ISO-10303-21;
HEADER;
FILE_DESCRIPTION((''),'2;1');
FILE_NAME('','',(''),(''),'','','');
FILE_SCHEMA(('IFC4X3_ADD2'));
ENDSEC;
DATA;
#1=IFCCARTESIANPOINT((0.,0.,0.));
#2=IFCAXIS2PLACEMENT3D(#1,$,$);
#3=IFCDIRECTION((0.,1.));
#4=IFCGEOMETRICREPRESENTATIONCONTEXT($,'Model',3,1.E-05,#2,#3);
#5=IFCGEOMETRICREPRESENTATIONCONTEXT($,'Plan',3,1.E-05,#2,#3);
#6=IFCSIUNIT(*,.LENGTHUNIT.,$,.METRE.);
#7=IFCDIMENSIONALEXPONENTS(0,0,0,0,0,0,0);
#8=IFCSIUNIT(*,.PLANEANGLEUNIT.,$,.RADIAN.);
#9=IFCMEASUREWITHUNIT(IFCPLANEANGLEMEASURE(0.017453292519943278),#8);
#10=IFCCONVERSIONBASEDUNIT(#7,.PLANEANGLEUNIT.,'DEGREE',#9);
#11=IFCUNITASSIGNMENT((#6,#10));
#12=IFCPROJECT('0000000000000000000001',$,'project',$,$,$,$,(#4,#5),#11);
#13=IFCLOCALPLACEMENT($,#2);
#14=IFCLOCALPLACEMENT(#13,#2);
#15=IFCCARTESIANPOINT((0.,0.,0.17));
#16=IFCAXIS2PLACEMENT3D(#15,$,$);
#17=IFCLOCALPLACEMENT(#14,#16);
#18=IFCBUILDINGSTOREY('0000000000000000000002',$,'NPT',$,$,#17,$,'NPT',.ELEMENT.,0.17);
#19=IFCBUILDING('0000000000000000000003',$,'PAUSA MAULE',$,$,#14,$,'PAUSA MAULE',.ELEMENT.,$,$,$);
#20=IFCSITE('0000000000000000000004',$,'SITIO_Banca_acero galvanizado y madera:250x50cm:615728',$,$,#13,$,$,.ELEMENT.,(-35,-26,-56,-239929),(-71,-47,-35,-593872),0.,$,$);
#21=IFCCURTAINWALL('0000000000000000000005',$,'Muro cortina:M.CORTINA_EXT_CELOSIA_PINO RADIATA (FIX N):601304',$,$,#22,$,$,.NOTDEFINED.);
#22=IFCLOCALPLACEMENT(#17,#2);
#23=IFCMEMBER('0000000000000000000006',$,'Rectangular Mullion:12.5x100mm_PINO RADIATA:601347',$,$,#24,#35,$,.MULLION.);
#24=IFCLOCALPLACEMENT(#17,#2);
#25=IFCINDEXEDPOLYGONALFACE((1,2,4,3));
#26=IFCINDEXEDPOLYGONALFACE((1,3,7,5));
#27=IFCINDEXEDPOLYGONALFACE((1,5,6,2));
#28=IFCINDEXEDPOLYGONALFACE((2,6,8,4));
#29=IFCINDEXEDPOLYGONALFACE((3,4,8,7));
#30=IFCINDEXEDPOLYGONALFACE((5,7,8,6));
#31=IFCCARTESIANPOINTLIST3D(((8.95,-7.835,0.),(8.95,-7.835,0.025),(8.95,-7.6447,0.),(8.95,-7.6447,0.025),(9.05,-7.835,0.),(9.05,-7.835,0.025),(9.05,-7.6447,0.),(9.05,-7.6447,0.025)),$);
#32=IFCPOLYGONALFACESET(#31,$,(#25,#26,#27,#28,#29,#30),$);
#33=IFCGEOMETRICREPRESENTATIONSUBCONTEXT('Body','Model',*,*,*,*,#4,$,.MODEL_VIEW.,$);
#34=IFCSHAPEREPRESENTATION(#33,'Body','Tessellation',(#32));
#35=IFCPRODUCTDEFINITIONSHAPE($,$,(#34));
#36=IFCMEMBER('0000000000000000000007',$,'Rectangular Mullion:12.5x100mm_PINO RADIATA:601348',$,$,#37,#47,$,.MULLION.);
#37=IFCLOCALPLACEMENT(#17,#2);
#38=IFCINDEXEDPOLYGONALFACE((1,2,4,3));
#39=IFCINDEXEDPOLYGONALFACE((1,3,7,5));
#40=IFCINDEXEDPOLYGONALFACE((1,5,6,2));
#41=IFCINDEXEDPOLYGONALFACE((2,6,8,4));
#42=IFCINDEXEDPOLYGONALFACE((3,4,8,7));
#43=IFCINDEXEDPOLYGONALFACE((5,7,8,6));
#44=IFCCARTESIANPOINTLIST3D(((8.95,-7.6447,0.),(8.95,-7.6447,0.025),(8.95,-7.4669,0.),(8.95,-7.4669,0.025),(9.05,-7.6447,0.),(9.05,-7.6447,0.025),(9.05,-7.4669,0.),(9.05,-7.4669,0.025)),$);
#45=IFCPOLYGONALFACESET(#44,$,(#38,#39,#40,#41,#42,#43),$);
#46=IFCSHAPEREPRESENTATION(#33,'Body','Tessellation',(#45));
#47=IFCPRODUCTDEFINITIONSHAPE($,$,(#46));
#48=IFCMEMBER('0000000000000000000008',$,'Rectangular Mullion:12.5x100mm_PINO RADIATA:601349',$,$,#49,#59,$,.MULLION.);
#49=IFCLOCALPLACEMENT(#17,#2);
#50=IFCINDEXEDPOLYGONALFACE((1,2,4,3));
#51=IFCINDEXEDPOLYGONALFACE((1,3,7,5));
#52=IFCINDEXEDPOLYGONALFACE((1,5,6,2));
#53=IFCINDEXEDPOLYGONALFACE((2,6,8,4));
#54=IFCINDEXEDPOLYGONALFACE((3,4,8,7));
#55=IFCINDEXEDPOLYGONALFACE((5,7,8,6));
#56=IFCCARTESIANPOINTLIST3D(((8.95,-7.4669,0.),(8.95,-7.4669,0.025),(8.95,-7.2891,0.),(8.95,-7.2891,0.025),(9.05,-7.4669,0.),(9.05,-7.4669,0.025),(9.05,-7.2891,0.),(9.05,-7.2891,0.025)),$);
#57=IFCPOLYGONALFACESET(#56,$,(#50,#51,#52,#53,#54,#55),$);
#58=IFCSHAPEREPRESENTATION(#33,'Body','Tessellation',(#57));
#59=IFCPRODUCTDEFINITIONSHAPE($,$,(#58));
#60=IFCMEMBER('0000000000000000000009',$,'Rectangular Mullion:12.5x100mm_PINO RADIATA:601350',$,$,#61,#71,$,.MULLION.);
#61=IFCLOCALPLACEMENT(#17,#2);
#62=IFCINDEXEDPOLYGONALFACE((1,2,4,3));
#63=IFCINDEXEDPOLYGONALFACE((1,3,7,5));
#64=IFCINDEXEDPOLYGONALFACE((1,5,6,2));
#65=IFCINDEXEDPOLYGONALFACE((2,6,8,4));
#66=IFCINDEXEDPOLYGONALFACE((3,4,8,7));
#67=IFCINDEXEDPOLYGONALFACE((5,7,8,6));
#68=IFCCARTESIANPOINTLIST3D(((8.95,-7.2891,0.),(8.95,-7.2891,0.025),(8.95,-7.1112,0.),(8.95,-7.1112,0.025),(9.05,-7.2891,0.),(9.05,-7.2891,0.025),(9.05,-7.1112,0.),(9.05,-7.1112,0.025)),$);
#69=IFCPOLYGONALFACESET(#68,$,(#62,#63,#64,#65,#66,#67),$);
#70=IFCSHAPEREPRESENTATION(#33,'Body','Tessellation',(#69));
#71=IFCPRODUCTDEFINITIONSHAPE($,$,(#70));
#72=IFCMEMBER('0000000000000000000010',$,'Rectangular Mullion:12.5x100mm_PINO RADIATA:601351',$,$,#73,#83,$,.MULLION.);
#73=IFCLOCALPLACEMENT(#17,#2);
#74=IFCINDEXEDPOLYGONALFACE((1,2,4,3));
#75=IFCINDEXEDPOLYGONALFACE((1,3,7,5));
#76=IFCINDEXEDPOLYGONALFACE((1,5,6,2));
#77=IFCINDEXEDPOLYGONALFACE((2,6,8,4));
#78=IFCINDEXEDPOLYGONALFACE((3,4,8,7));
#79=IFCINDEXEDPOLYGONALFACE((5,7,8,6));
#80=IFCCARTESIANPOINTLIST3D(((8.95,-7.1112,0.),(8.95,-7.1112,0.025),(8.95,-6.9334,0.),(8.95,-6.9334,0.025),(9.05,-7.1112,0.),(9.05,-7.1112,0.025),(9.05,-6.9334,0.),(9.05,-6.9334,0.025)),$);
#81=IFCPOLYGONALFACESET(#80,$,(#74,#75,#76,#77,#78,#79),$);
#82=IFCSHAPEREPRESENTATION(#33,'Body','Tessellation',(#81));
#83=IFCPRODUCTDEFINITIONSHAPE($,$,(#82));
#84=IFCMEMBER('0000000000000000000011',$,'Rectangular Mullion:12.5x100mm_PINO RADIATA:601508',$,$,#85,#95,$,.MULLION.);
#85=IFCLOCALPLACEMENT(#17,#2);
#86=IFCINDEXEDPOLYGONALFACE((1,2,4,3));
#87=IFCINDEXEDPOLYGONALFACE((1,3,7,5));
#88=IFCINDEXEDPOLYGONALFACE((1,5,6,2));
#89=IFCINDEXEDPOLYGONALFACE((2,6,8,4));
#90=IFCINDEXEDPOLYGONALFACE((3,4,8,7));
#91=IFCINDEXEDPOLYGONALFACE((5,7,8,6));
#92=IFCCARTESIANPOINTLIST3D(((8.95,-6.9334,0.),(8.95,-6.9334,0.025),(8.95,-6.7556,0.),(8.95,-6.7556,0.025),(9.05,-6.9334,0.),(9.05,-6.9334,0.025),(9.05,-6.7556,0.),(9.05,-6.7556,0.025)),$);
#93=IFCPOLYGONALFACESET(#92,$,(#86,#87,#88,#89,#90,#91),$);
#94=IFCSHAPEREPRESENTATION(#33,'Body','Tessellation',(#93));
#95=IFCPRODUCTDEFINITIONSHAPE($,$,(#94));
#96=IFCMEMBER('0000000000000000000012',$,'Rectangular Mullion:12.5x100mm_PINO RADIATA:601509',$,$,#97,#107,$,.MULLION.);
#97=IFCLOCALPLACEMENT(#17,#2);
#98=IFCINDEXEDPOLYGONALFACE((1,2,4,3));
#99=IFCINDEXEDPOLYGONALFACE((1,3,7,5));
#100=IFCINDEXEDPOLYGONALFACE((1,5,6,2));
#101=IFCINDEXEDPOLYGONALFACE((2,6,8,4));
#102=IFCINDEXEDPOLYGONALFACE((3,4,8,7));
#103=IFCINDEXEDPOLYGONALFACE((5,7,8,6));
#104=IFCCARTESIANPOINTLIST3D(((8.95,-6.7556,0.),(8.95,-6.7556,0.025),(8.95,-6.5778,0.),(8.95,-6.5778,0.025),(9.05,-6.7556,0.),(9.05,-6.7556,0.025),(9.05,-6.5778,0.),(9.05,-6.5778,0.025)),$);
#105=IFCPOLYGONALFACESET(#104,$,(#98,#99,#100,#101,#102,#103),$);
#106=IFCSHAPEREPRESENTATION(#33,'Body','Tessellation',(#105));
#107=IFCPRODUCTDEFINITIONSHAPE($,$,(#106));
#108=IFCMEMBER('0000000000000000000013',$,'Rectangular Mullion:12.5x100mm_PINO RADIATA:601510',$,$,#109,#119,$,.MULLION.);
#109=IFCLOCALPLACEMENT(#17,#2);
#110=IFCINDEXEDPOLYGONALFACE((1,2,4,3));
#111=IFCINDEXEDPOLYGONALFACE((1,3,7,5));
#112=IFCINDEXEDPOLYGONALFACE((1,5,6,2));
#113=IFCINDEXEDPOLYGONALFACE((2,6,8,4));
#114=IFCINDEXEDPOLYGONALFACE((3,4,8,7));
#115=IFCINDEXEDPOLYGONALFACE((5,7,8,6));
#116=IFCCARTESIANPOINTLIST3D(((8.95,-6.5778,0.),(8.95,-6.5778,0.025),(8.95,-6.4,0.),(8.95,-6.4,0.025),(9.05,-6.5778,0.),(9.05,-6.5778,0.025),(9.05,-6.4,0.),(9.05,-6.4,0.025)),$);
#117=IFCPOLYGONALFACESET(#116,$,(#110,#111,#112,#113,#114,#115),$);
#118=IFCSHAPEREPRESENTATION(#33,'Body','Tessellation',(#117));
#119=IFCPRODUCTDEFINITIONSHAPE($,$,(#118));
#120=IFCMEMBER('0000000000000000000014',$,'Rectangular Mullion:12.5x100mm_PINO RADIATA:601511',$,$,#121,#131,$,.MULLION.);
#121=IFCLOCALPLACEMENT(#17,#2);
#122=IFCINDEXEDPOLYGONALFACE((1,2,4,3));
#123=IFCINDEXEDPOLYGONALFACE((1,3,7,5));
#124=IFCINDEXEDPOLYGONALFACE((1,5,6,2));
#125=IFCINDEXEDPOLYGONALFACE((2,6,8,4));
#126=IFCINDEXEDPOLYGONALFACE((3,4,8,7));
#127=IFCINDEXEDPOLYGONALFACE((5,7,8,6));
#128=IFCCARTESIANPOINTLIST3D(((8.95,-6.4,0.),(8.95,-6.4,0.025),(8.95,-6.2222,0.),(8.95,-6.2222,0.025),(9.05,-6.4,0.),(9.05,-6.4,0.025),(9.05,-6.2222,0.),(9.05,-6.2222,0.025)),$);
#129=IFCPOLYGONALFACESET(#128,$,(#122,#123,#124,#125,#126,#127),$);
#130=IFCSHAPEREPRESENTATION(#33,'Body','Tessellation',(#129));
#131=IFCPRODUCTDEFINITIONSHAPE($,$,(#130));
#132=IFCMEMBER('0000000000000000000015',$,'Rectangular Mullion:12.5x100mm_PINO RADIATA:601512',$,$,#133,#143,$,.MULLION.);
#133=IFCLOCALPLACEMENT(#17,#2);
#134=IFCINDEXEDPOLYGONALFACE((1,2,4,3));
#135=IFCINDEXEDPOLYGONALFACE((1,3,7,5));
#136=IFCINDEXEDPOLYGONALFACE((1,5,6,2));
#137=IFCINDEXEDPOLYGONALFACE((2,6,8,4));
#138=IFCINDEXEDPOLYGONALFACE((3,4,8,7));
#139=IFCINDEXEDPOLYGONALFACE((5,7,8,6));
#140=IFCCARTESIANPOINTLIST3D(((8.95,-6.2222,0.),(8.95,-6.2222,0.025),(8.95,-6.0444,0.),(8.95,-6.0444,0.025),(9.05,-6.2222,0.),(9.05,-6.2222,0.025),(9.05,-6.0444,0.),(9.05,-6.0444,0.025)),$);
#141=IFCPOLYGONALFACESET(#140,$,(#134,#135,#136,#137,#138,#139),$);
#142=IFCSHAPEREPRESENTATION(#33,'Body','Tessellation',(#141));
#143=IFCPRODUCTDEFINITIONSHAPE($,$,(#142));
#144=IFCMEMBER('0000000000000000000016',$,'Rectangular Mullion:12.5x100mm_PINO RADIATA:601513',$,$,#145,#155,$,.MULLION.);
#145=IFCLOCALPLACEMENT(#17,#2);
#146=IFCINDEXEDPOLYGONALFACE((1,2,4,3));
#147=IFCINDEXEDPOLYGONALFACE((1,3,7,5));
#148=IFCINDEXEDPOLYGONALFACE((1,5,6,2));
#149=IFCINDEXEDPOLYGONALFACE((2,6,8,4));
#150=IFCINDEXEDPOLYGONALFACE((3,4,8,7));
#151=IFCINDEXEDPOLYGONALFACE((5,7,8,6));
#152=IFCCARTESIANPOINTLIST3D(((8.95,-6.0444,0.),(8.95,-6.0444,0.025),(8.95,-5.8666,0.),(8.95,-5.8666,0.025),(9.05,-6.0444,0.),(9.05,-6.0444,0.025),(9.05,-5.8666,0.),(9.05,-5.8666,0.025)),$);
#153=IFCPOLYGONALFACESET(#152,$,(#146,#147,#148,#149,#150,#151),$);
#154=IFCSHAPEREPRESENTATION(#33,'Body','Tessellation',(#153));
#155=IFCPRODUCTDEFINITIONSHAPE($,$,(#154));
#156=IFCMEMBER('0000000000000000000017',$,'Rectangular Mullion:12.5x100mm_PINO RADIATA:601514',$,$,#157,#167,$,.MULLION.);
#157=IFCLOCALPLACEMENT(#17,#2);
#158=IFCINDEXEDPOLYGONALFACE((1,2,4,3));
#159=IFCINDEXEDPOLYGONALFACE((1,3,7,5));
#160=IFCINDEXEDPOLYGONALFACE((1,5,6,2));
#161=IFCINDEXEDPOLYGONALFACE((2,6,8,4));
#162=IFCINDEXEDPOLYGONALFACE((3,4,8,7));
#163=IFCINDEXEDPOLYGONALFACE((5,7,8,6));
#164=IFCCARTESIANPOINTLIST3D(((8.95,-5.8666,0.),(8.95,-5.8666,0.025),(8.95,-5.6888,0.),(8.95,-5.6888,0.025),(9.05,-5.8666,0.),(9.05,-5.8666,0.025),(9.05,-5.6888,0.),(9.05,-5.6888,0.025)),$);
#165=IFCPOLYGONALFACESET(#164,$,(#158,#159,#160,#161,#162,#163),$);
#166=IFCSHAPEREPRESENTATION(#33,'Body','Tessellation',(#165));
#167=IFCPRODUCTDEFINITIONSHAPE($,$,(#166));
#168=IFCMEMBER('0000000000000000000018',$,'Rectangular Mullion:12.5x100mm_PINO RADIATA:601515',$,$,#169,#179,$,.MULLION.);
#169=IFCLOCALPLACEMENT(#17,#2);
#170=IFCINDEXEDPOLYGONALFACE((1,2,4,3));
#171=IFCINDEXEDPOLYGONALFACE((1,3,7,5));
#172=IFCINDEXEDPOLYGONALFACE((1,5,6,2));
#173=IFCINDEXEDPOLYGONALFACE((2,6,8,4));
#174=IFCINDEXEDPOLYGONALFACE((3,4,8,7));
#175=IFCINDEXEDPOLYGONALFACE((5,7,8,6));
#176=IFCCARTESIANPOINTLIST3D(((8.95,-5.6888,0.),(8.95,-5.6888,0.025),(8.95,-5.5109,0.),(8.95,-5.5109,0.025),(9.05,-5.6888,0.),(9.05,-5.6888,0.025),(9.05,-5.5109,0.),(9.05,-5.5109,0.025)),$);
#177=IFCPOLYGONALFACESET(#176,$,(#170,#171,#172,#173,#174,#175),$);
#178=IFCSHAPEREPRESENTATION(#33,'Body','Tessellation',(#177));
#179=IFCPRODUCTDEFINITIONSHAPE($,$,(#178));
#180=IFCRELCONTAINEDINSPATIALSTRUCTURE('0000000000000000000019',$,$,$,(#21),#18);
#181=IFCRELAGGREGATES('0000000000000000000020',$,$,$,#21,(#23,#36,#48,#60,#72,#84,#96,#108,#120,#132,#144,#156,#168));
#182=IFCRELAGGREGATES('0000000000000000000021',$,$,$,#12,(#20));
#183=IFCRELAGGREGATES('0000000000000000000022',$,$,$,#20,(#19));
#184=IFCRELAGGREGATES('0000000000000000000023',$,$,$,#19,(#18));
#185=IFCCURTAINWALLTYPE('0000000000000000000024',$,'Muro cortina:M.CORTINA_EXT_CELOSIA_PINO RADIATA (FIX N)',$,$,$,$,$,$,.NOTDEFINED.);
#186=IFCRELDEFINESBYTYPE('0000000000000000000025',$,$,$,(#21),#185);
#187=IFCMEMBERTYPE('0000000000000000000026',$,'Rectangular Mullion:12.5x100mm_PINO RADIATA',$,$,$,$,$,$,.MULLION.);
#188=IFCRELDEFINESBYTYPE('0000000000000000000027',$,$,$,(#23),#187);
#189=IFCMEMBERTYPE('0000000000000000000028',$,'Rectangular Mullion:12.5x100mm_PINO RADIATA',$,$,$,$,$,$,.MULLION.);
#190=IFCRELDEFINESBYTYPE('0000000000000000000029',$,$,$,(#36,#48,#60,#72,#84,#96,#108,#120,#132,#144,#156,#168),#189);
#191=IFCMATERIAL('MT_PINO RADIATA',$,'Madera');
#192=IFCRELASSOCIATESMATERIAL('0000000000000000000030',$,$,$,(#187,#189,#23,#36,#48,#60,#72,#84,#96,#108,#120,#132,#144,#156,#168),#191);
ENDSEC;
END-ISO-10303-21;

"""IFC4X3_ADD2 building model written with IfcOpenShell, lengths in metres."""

from ifc_helpers import new_model, entity, si_unit, converted_unit, direction, frame, frame_2d, origin, place, context, subcontext, project, spatial, rectangle, extrude, source, transform, mapped, material, material_profile, profile_set, profile_usage, type_object, type_shapes, element, aggregate, save


model = new_model("IFC4X3_ADD2")

# Units and contexts
model_context = context("Model", 3, precision=1e-05, world=origin(), true_north=direction((0.0, 1.0)))
plan_context = context("Plan", 3, precision=1e-05, world=origin(), true_north=direction((0.0, 1.0)))
body_context = subcontext(model_context, "Body", "Model", "MODEL_VIEW")
ifc_project = project(units=[si_unit("LENGTHUNIT", "METRE"), converted_unit("PLANEANGLEUNIT", "DEGREE", entity("IfcPlaneAngleMeasure", 0.017453292519943278), si_unit("PLANEANGLEUNIT", "RADIAN"), dimensions=[0, 0, 0, 0, 0, 0, 0])], contexts=[model_context, plan_context])

# Site, building, storey
site_placement = place(None, origin())
site = spatial("IfcSite", under=ifc_project, at=site_placement, Name="SITIO_Banca_acero galvanizado y madera:250x50cm:615728", CompositionType="ELEMENT", RefLatitude=(-35, -26, -56, -239929), RefLongitude=(-71, -47, -35, -593872), RefElevation=0.0)
building_placement = place(site_placement, origin())
building = spatial("IfcBuilding", under=site, at=building_placement, Name="PAUSA MAULE", LongName="PAUSA MAULE", CompositionType="ELEMENT")
storey_placement = place(building_placement, frame((0.0, 0.0, 0.17)))
storey = spatial("IfcBuildingStorey", under=building, at=storey_placement, Name="NPT", LongName="NPT", CompositionType="ELEMENT", Elevation=0.17)

# Curtain wall, members
curtain_wall_type = type_object("IfcCurtainWallType", Name="Muro cortina:M.CORTINA_EXT_CELOSIA_PINO RADIATA (FIX N)", PredefinedType="NOTDEFINED")
curtain_wall_placement = place(storey_placement, frame((0.0, 0.0, -0.17)))
curtain_wall = element("IfcCurtainWall", 1, at=curtain_wall_placement, inside=storey, type_object=curtain_wall_type, Name="Muro cortina:M.CORTINA_EXT_CELOSIA_PINO RADIATA (FIX N):601304", PredefinedType="NOTDEFINED")
ifc_material = material(Name="MT_PINO RADIATA", Category="Madera")
ifc_material_profile = material_profile(ifc_material, rectangle(XDim=0.025, YDim=0.1, at=frame_2d((0.0, 0.0), x_axis=(1.0, 0.0))), Name="12.5x100mm_PINO RADIATA")
ifc_profile_set = profile_set([ifc_material_profile], Name="12.5x100mm_PINO RADIATA")
ifc_profile_usage = profile_usage(ifc_profile_set)
member_type_1 = type_object("IfcMemberType", Name="Rectangular Mullion:12.5x100mm_PINO RADIATA", PredefinedType="MULLION", material=ifc_profile_set)
shared_shape_1 = source(origin(), body_context, "Body", "SweptSolid", [
    extrude(rectangle(XDim=0.025, YDim=0.1, at=frame_2d((0.0, 0.0), x_axis=(1.0, 0.0))), frame((-0.0125, 0.0, -0.1903), z_axis=(0.0, 0.0, 1.0), x_axis=(-1.0, 0.0, 0.0)), (0.0, 0.0, 1.0), 0.1903),
])
type_shapes(member_type_1, [shared_shape_1])
member_1_placement = place(curtain_wall_placement, frame((9.0, -7.835, 0.17), z_axis=(0.0, -1.0, 0.0), x_axis=(0.0, 0.0, -1.0)))
member_1 = element("IfcMember", 2, at=member_1_placement, type_object=member_type_1, material=ifc_profile_usage, Name="Rectangular Mullion:12.5x100mm_PINO RADIATA:601347", PredefinedType="MULLION", context=body_context, shape_type="MappedRepresentation", body=[
    mapped(shared_shape_1, transform((0.0, 0.0, 0.0), scale=1.0)),
])
member_type_2 = type_object("IfcMemberType", Name="Rectangular Mullion:12.5x100mm_PINO RADIATA", PredefinedType="MULLION", material=ifc_profile_set)
shared_shape_2 = source(origin(), body_context, "Body", "SweptSolid", [
    extrude(rectangle(XDim=0.025, YDim=0.1, at=frame_2d((0.0, 0.0), x_axis=(1.0, 0.0))), frame((-0.0125, 0.0, -0.1778), z_axis=(0.0, 0.0, 1.0), x_axis=(-1.0, 0.0, 0.0)), (0.0, 0.0, 1.0), 0.1778),
])
type_shapes(member_type_2, [shared_shape_2])
member_2_placement = place(curtain_wall_placement, frame((9.0, -7.6447, 0.17), z_axis=(0.0, -1.0, 0.0), x_axis=(0.0, 0.0, -1.0)))
member_2 = element("IfcMember", 3, at=member_2_placement, type_object=member_type_2, material=ifc_profile_usage, Name="Rectangular Mullion:12.5x100mm_PINO RADIATA:601348", PredefinedType="MULLION", context=body_context, shape_type="MappedRepresentation", body=[
    mapped(shared_shape_2, transform((0.0, 0.0, 0.0), scale=1.0)),
])
member_3_placement = place(curtain_wall_placement, frame((9.0, -7.4669, 0.17), z_axis=(0.0, -1.0, 0.0), x_axis=(0.0, 0.0, -1.0)))
member_3 = element("IfcMember", 4, at=member_3_placement, type_object=member_type_2, material=ifc_profile_usage, Name="Rectangular Mullion:12.5x100mm_PINO RADIATA:601349", PredefinedType="MULLION", context=body_context, shape_type="MappedRepresentation", body=[
    mapped(shared_shape_2, transform((0.0, 0.0, 0.0), scale=1.0)),
])
member_4_placement = place(curtain_wall_placement, frame((9.0, -7.2891, 0.17), z_axis=(0.0, -1.0, 0.0), x_axis=(0.0, 0.0, -1.0)))
member_4 = element("IfcMember", 5, at=member_4_placement, type_object=member_type_2, material=ifc_profile_usage, Name="Rectangular Mullion:12.5x100mm_PINO RADIATA:601350", PredefinedType="MULLION", context=body_context, shape_type="MappedRepresentation", body=[
    mapped(shared_shape_2, transform((0.0, 0.0, 0.0), scale=1.0)),
])
member_5_placement = place(curtain_wall_placement, frame((9.0, -7.1112, 0.17), z_axis=(0.0, -1.0, 0.0), x_axis=(0.0, 0.0, -1.0)))
member_5 = element("IfcMember", 6, at=member_5_placement, type_object=member_type_2, material=ifc_profile_usage, Name="Rectangular Mullion:12.5x100mm_PINO RADIATA:601351", PredefinedType="MULLION", context=body_context, shape_type="MappedRepresentation", body=[
    mapped(shared_shape_2, transform((0.0, 0.0, 0.0), scale=1.0)),
])
member_6_placement = place(curtain_wall_placement, frame((9.0, -6.9334, 0.17), z_axis=(0.0, -1.0, 0.0), x_axis=(0.0, 0.0, -1.0)))
member_6 = element("IfcMember", 7, at=member_6_placement, type_object=member_type_2, material=ifc_profile_usage, Name="Rectangular Mullion:12.5x100mm_PINO RADIATA:601508", PredefinedType="MULLION", context=body_context, shape_type="MappedRepresentation", body=[
    mapped(shared_shape_2, transform((0.0, 0.0, 0.0), scale=1.0)),
])
member_7_placement = place(curtain_wall_placement, frame((9.0, -6.7556, 0.17), z_axis=(0.0, -1.0, 0.0), x_axis=(0.0, 0.0, -1.0)))
member_7 = element("IfcMember", 8, at=member_7_placement, type_object=member_type_2, material=ifc_profile_usage, Name="Rectangular Mullion:12.5x100mm_PINO RADIATA:601509", PredefinedType="MULLION", context=body_context, shape_type="MappedRepresentation", body=[
    mapped(shared_shape_2, transform((0.0, 0.0, 0.0), scale=1.0)),
])
member_8_placement = place(curtain_wall_placement, frame((9.0, -6.5778, 0.17), z_axis=(0.0, -1.0, 0.0), x_axis=(0.0, 0.0, -1.0)))
member_8 = element("IfcMember", 9, at=member_8_placement, type_object=member_type_2, material=ifc_profile_usage, Name="Rectangular Mullion:12.5x100mm_PINO RADIATA:601510", PredefinedType="MULLION", context=body_context, shape_type="MappedRepresentation", body=[
    mapped(shared_shape_2, transform((0.0, 0.0, 0.0), scale=1.0)),
])
member_9_placement = place(curtain_wall_placement, frame((9.0, -6.4, 0.17), z_axis=(0.0, -1.0, 0.0), x_axis=(0.0, 0.0, -1.0)))
member_9 = element("IfcMember", 10, at=member_9_placement, type_object=member_type_2, material=ifc_profile_usage, Name="Rectangular Mullion:12.5x100mm_PINO RADIATA:601511", PredefinedType="MULLION", context=body_context, shape_type="MappedRepresentation", body=[
    mapped(shared_shape_2, transform((0.0, 0.0, 0.0), scale=1.0)),
])
member_10_placement = place(curtain_wall_placement, frame((9.0, -6.2222, 0.17), z_axis=(0.0, -1.0, 0.0), x_axis=(0.0, 0.0, -1.0)))
member_10 = element("IfcMember", 11, at=member_10_placement, type_object=member_type_2, material=ifc_profile_usage, Name="Rectangular Mullion:12.5x100mm_PINO RADIATA:601512", PredefinedType="MULLION", context=body_context, shape_type="MappedRepresentation", body=[
    mapped(shared_shape_2, transform((0.0, 0.0, 0.0), scale=1.0)),
])
member_11_placement = place(curtain_wall_placement, frame((9.0, -6.0444, 0.17), z_axis=(0.0, -1.0, 0.0), x_axis=(0.0, 0.0, -1.0)))
member_11 = element("IfcMember", 12, at=member_11_placement, type_object=member_type_2, material=ifc_profile_usage, Name="Rectangular Mullion:12.5x100mm_PINO RADIATA:601513", PredefinedType="MULLION", context=body_context, shape_type="MappedRepresentation", body=[
    mapped(shared_shape_2, transform((0.0, 0.0, 0.0), scale=1.0)),
])
member_12_placement = place(curtain_wall_placement, frame((9.0, -5.8666, 0.17), z_axis=(0.0, -1.0, 0.0), x_axis=(0.0, 0.0, -1.0)))
member_12 = element("IfcMember", 13, at=member_12_placement, type_object=member_type_2, material=ifc_profile_usage, Name="Rectangular Mullion:12.5x100mm_PINO RADIATA:601514", PredefinedType="MULLION", context=body_context, shape_type="MappedRepresentation", body=[
    mapped(shared_shape_2, transform((0.0, 0.0, 0.0), scale=1.0)),
])
member_13_placement = place(curtain_wall_placement, frame((9.0, -5.6888, 0.17), z_axis=(0.0, -1.0, 0.0), x_axis=(0.0, 0.0, -1.0)))
member_13 = element("IfcMember", 14, at=member_13_placement, type_object=member_type_2, material=ifc_profile_usage, Name="Rectangular Mullion:12.5x100mm_PINO RADIATA:601515", PredefinedType="MULLION", context=body_context, shape_type="MappedRepresentation", body=[
    mapped(shared_shape_2, transform((0.0, 0.0, 0.0), scale=1.0)),
])
aggregate(curtain_wall, [member_1, member_2, member_3, member_4, member_5, member_6, member_7, member_8, member_9, member_10, member_11, member_12, member_13])

save(model, "model.ifc")
